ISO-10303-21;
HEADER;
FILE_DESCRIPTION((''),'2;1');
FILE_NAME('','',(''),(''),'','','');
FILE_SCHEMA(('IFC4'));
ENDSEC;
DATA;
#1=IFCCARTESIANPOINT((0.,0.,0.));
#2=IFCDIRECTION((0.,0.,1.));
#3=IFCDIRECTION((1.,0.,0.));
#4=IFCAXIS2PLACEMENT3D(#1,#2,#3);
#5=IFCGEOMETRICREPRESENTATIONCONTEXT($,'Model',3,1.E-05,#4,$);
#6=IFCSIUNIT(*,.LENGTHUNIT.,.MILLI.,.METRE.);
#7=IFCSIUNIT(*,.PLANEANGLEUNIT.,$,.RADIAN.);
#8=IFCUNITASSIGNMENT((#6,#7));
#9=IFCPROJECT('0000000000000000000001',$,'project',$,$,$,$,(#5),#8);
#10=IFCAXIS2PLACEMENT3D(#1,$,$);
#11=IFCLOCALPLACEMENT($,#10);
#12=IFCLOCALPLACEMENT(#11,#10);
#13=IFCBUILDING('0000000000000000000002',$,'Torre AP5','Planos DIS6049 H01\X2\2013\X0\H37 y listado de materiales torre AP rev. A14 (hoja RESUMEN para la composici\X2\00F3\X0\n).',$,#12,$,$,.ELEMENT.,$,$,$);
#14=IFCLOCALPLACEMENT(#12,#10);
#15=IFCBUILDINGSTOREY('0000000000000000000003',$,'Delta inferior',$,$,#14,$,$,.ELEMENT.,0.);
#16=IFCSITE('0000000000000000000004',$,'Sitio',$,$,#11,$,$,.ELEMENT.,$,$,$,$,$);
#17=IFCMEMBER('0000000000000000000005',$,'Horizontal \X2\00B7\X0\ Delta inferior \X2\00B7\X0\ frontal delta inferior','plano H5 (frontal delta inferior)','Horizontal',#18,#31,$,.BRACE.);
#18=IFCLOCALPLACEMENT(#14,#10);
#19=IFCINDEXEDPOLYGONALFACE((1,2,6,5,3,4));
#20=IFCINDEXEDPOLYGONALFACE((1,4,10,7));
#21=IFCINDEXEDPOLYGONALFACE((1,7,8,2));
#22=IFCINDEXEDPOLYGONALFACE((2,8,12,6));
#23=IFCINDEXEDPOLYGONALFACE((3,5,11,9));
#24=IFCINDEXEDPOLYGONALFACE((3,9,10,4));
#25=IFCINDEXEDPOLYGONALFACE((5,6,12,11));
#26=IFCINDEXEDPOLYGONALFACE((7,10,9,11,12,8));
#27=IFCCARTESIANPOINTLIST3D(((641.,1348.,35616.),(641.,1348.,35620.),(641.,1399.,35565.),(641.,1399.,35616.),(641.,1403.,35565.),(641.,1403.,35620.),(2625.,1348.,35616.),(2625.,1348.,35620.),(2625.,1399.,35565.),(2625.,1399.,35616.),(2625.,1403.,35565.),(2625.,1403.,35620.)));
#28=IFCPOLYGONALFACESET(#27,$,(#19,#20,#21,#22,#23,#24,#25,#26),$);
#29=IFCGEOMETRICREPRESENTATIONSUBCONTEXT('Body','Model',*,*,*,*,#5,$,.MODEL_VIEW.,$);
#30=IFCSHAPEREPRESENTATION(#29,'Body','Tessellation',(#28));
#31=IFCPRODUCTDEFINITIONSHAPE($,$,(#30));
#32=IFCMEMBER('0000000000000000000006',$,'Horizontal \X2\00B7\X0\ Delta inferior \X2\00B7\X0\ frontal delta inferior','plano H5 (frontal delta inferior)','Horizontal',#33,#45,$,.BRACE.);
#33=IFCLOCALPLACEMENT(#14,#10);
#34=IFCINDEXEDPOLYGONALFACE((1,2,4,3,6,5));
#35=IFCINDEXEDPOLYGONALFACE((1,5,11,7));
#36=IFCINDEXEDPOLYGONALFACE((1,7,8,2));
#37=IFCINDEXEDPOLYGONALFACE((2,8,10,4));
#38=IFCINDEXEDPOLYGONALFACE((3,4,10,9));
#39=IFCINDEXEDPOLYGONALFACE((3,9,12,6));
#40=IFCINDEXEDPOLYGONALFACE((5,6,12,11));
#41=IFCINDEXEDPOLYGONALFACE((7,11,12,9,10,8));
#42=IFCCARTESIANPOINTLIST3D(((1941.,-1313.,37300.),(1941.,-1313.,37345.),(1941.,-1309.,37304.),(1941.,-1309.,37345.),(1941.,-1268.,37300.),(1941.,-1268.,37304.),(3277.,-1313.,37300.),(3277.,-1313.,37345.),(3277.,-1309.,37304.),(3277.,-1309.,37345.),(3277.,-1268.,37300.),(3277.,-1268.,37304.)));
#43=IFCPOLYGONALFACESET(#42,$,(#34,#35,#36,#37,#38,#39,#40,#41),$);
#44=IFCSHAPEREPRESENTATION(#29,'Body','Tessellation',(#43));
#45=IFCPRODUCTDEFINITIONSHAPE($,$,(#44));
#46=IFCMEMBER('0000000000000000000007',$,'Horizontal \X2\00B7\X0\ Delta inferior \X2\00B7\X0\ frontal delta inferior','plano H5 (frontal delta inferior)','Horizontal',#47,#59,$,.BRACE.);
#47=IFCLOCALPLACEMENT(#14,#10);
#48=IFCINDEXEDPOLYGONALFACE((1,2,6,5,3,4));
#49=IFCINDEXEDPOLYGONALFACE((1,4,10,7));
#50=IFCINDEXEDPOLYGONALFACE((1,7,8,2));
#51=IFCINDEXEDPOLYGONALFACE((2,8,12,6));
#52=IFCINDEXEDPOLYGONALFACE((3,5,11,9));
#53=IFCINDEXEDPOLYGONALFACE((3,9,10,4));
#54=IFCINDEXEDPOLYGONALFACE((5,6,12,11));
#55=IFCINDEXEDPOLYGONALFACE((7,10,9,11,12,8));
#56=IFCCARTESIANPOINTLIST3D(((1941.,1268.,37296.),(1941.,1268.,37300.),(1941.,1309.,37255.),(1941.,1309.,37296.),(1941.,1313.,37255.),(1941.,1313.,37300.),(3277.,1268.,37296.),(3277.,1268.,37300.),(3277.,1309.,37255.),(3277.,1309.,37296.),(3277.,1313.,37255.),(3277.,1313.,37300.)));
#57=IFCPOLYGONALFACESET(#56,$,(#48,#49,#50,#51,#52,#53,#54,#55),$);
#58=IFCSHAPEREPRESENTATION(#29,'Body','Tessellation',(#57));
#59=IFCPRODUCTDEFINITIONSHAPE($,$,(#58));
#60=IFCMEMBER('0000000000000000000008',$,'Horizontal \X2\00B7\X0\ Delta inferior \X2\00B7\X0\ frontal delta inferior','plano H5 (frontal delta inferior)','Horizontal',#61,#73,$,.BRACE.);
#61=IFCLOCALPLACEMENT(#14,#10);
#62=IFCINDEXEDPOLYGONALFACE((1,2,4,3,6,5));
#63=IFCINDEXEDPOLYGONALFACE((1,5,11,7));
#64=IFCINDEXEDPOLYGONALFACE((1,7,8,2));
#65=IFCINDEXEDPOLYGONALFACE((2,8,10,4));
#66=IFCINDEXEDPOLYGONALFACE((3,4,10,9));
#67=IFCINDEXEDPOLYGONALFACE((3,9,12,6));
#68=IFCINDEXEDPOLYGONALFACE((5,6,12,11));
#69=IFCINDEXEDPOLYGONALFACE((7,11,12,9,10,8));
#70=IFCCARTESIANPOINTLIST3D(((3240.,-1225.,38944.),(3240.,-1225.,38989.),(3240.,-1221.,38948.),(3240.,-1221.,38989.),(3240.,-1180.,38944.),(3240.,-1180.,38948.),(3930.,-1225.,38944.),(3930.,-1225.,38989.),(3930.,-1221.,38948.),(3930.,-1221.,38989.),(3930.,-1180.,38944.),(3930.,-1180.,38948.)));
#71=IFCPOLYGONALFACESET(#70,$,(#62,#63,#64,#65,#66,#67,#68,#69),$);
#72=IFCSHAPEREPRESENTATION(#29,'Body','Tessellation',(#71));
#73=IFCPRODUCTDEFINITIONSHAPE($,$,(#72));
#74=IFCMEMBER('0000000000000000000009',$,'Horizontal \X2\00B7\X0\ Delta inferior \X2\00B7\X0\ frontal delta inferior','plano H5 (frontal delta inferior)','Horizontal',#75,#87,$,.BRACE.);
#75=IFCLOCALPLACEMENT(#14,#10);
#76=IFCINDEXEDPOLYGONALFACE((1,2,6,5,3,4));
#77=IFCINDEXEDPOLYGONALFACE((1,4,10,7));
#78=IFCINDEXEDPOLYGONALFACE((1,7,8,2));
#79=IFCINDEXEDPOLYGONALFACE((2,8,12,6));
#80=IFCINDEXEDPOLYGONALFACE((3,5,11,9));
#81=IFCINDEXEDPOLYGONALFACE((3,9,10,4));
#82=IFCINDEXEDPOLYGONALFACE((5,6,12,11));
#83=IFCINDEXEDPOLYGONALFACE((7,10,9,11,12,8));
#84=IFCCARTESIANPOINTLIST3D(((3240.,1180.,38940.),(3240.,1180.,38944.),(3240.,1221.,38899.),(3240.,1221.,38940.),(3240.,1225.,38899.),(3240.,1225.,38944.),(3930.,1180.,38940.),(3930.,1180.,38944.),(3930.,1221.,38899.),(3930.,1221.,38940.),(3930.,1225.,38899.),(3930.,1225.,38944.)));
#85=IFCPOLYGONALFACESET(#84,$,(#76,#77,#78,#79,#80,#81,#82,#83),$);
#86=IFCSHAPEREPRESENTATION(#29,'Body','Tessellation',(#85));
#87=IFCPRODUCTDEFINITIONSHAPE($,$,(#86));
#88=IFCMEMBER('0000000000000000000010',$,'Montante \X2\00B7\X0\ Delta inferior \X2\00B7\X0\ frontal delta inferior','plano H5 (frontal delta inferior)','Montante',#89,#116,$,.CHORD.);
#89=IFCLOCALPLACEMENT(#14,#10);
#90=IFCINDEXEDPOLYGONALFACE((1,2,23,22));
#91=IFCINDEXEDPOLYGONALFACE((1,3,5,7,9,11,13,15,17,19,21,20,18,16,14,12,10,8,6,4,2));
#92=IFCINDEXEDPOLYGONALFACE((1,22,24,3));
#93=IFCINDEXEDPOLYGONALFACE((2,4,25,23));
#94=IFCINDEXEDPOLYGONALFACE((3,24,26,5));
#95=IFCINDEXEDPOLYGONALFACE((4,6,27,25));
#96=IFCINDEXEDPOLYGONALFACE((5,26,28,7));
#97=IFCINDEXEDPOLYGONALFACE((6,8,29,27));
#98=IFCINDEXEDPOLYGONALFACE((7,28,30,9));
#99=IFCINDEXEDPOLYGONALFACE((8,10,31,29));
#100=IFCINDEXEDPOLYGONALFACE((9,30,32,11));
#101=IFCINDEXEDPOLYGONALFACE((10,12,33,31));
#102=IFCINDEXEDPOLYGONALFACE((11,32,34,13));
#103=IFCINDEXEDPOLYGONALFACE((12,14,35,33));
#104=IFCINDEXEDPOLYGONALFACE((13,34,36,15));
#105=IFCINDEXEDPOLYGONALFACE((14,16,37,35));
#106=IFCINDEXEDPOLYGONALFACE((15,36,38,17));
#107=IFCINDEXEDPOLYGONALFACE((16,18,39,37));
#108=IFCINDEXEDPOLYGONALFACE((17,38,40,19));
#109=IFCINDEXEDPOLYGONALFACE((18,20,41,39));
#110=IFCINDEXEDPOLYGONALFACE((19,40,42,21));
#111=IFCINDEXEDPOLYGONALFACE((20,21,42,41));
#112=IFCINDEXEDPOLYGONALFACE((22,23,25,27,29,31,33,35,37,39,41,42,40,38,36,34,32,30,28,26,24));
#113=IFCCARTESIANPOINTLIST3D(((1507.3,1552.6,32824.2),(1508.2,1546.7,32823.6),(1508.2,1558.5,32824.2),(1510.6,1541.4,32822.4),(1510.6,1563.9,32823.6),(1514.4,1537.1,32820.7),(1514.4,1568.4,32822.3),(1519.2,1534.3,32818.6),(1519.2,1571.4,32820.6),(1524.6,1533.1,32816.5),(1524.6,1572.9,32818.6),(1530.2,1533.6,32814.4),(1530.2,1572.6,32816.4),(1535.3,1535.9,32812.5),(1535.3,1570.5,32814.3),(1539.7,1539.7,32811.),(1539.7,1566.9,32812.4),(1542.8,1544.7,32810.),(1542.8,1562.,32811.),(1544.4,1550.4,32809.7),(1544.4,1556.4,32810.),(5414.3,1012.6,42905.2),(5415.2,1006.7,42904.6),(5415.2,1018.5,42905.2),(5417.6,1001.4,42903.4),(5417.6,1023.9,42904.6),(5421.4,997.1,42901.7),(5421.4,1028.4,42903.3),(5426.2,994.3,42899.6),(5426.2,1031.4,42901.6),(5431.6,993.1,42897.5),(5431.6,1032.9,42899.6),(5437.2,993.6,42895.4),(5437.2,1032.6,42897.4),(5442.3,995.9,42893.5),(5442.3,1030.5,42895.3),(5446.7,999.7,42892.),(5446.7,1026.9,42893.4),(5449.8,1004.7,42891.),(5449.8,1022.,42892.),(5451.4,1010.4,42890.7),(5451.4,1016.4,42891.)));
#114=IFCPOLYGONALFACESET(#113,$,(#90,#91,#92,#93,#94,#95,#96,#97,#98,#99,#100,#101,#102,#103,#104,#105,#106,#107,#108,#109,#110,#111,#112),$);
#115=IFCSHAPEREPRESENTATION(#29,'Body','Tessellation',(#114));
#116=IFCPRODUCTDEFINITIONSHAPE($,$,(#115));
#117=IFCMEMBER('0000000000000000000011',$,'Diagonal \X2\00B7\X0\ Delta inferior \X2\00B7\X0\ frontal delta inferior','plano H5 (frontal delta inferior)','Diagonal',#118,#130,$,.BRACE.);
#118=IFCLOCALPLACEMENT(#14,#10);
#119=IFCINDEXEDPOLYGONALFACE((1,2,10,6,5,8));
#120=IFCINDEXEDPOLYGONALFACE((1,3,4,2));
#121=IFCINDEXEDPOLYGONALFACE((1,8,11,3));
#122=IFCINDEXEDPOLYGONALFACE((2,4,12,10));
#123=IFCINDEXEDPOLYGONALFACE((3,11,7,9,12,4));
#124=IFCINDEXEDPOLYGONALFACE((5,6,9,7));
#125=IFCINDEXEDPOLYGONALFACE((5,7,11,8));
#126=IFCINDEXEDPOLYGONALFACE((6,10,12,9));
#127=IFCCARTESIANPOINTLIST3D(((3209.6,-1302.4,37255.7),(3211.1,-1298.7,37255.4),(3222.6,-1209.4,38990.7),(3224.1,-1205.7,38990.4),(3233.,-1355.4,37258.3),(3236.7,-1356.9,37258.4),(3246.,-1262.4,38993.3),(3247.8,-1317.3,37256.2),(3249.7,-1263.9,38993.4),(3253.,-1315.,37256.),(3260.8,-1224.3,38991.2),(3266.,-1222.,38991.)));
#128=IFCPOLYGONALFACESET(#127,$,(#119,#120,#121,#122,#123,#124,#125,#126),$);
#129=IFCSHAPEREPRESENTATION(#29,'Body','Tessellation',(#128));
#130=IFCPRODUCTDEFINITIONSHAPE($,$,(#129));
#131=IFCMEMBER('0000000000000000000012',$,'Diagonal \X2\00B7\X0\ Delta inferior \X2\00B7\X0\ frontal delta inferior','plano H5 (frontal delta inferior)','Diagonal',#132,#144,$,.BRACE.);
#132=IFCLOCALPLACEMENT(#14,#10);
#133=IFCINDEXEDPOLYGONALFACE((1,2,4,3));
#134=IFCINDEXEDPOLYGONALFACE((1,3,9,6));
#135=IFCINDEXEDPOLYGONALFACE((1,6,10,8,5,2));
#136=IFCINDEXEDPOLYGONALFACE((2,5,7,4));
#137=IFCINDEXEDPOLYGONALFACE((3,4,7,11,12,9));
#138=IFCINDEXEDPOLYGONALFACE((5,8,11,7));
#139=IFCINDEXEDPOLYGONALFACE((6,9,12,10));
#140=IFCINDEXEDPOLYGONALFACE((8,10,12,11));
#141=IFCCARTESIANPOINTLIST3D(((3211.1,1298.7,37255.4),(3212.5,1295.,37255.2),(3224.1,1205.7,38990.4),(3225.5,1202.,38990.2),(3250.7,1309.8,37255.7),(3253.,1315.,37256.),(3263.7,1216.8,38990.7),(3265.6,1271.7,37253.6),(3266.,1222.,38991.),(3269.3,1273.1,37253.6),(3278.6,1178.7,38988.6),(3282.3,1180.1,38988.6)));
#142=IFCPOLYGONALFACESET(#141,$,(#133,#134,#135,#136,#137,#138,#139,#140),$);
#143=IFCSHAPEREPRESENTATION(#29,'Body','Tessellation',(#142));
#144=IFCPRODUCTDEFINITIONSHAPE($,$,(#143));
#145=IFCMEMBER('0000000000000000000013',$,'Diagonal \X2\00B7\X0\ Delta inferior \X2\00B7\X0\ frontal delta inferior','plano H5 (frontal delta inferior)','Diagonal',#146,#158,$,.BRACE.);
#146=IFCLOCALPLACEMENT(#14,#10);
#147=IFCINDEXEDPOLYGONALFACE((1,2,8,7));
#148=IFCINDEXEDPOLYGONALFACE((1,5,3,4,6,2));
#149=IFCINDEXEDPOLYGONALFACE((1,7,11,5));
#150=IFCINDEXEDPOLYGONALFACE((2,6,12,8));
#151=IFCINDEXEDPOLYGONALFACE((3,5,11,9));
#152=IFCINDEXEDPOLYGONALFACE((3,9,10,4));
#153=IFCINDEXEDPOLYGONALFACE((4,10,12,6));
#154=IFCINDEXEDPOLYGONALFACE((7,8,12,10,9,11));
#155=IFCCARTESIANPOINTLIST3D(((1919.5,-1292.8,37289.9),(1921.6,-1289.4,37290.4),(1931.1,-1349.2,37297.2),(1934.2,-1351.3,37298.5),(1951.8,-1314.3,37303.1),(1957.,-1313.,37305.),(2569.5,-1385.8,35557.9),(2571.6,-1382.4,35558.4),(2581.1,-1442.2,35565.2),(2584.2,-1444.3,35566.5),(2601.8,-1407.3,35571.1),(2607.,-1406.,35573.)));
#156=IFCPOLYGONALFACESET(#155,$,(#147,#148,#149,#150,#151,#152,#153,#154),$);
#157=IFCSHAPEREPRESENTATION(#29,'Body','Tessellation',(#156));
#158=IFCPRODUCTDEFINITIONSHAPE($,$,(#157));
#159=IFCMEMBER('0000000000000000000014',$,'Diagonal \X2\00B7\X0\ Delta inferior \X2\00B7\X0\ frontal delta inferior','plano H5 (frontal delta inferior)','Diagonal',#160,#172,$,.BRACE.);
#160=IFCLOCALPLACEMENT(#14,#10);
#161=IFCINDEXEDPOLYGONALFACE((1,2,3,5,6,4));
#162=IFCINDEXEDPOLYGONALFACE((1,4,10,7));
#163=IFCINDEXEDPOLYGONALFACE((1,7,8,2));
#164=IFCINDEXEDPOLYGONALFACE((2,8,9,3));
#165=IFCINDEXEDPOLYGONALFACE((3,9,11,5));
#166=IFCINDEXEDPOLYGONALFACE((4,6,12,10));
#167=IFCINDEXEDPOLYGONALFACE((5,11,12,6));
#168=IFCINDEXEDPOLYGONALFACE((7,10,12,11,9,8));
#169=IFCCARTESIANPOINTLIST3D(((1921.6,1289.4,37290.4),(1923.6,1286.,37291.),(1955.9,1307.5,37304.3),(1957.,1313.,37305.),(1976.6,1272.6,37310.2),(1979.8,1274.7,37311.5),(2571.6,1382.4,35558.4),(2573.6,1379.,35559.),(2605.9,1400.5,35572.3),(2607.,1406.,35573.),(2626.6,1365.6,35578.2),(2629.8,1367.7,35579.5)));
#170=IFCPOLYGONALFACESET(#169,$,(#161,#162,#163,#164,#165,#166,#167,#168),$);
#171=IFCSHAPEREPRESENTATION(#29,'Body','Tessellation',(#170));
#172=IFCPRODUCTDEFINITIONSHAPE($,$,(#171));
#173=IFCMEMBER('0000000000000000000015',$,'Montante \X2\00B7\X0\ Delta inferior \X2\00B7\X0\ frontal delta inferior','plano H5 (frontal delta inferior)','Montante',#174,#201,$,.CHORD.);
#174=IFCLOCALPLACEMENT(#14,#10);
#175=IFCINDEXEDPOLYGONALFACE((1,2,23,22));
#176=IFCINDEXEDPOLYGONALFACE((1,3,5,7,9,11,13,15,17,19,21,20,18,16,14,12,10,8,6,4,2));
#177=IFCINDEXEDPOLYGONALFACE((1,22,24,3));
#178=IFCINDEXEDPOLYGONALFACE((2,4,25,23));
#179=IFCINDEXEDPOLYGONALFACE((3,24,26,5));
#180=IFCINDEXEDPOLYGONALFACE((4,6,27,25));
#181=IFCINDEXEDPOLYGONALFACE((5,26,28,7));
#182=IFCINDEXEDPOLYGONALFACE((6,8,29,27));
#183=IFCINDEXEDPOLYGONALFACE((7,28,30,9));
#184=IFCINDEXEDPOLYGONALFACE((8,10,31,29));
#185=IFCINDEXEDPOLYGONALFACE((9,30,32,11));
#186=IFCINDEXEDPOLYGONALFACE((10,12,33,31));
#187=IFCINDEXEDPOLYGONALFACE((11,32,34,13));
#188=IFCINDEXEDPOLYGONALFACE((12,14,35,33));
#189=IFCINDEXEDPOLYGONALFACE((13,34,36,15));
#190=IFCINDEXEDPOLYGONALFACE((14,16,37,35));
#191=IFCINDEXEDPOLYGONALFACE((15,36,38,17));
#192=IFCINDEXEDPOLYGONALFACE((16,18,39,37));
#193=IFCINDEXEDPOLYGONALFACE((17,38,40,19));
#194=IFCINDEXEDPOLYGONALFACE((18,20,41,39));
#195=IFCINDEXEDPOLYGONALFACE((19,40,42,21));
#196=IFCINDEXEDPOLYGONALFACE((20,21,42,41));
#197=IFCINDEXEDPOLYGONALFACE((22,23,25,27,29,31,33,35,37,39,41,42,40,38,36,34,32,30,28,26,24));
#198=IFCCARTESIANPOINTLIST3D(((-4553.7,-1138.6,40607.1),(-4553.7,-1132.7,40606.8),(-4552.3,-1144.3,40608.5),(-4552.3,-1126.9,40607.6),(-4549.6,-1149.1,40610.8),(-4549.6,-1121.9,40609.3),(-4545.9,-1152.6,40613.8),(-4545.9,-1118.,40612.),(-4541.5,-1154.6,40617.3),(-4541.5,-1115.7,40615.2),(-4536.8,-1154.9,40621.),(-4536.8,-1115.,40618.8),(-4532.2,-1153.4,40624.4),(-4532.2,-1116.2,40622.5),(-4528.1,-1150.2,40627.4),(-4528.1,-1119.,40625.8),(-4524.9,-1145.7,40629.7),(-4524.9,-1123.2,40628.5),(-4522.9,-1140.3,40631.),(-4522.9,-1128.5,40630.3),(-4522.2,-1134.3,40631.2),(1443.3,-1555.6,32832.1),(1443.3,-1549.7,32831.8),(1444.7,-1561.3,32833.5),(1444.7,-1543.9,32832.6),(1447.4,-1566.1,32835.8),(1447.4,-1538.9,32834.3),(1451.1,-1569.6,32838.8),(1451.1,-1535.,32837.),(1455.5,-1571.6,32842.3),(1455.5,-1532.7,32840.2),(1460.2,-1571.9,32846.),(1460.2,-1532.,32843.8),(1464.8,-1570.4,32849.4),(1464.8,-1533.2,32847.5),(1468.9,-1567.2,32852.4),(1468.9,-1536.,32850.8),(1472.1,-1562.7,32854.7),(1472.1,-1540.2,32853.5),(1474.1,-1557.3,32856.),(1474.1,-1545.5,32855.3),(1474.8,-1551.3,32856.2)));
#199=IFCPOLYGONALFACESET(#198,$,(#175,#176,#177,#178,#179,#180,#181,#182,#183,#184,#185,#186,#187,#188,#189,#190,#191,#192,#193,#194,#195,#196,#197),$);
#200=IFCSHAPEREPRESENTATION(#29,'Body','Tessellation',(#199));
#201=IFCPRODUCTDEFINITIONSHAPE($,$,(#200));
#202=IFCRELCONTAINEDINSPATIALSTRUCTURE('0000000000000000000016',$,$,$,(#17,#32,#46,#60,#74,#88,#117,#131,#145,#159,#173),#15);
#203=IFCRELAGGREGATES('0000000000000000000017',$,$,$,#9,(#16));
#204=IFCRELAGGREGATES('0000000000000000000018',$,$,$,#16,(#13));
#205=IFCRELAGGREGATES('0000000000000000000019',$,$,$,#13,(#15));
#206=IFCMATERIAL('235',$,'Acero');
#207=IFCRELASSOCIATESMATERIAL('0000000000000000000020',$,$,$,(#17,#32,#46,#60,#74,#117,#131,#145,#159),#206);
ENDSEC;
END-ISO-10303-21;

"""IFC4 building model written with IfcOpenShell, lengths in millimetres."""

from ifc_helpers import new_model, si_unit, frame, frame_2d, origin, origin_with_axes, place, context, subcontext, project, spatial, circle, l_section, extrude, material, element, save


model = new_model("IFC4")

# Units and contexts
model_context = context("Model", 3, precision=1e-05, world=origin_with_axes())
body_context = subcontext(model_context, "Body", "Model", "MODEL_VIEW")
ifc_project = project(units=[si_unit("LENGTHUNIT", "METRE", prefix="MILLI"), si_unit("PLANEANGLEUNIT", "RADIAN")], contexts=[model_context])

# Site, building, storey
site_placement = place(None, origin())
site = spatial("IfcSite", under=ifc_project, at=site_placement, Name="Sitio", CompositionType="ELEMENT")
building_placement = place(site_placement, origin())
building = spatial("IfcBuilding", under=site, at=building_placement, Name="Torre AP5", Description="Planos DIS6049 H01–H37 y listado de materiales torre AP rev. A14 (hoja RESUMEN para la composición).", CompositionType="ELEMENT")
storey_placement = place(building_placement, origin())
storey = spatial("IfcBuildingStorey", under=building, at=storey_placement, Name="Delta inferior", CompositionType="ELEMENT", Elevation=0.0)

# Members
ifc_material_1 = material(Name="235", Category="Acero")
member_1_placement = place(storey_placement, frame((641.0, 1403.0, 35620.0), z_axis=(1.0, 0.0, 0.0), x_axis=(0.0, -1.0, 0.0)))
element("IfcMember", 1, at=member_1_placement, inside=storey, material=ifc_material_1, Name="Horizontal · Delta inferior · frontal delta inferior", Description="plano H5 (frontal delta inferior)", ObjectType="Horizontal", PredefinedType="BRACE", context=body_context, shape_type="SweptSolid", body=[
    extrude(l_section(Depth=55.0, Width=55.0, Thickness=4.0, at=frame_2d((27.5, 27.5))), None, (0.0, 0.0, 1.0), 1984.0),
])
for number, where, z_axis, x_axis, name in (
    (2, (1941.0, -1313.0, 37300.0), (1.0, 0.0, 0.0), (0.0, 1.0, 0.0), "Horizontal · Delta inferior · frontal delta inferior"),
    (3, (1941.0, 1313.0, 37300.0), (1.0, 0.0, 0.0), (0.0, -1.0, 0.0), "Horizontal · Delta inferior · frontal delta inferior"),
):
    element("IfcMember", number, at=place(storey_placement, frame(where, z_axis=z_axis, x_axis=x_axis)), inside=storey, material=ifc_material_1, Name=name, Description="plano H5 (frontal delta inferior)", ObjectType="Horizontal", PredefinedType="BRACE", context=body_context, shape_type="SweptSolid", body=[
        extrude(l_section(Depth=45.0, Width=45.0, Thickness=4.0, at=frame_2d((22.5, 22.5))), None, (0.0, 0.0, 1.0), 1336.0),
    ])
for number, where, z_axis, x_axis, name in (
    (4, (3240.0, -1225.0, 38944.0), (1.0, 0.0, 0.0), (0.0, 1.0, 0.0), "Horizontal · Delta inferior · frontal delta inferior"),
    (5, (3240.0, 1225.0, 38944.0), (1.0, 0.0, 0.0), (0.0, -1.0, 0.0), "Horizontal · Delta inferior · frontal delta inferior"),
):
    element("IfcMember", number, at=place(storey_placement, frame(where, z_axis=z_axis, x_axis=x_axis)), inside=storey, material=ifc_material_1, Name=name, Description="plano H5 (frontal delta inferior)", ObjectType="Horizontal", PredefinedType="BRACE", context=body_context, shape_type="SweptSolid", body=[
        extrude(l_section(Depth=45.0, Width=45.0, Thickness=4.0, at=frame_2d((22.5, 22.5))), None, (0.0, 0.0, 1.0), 690.0),
    ])
for number, where, z_axis, x_axis, name in (
    (6, (1526.0, 1553.0, 32817.0), (0.36092, -0.049884, 0.931262), (-0.932597, -0.019305, 0.360404), "Montante · Delta inferior · frontal delta inferior"),
):
    element("IfcMember", number, at=place(storey_placement, frame(where, z_axis=z_axis, x_axis=x_axis)), inside=storey, Name=name, Description="plano H5 (frontal delta inferior)", ObjectType="Montante", PredefinedType="CHORD", context=body_context, shape_type="SweptSolid", body=[
        extrude(circle(Radius=20.0), None, (0.0, 0.0, 1.0), 10825.1),
    ])
for number, where, z_axis, x_axis, name in (
    (7, (3253.0, -1315.0, 37256.0), (0.007482, 0.053524, 0.998539), (-0.932081, 0.362036, -0.012422), "Diagonal · Delta inferior · frontal delta inferior"),
    (8, (3253.0, 1315.0, 37256.0), (0.007482, -0.053524, 0.998539), (-0.932081, -0.362036, -0.012422), "Diagonal · Delta inferior · frontal delta inferior"),
):
    element("IfcMember", number, at=place(storey_placement, frame(where, z_axis=z_axis, x_axis=x_axis)), inside=storey, material=ifc_material_1, Name=name, Description="plano H5 (frontal delta inferior)", ObjectType="Diagonal", PredefinedType="BRACE", context=body_context, shape_type="SweptSolid", body=[
        extrude(l_section(Depth=45.0, Width=45.0, Thickness=4.0, at=frame_2d((22.5, 22.5))), None, (0.0, 0.0, 1.0), 1737.5),
    ])
for number, where, z_axis, x_axis, name in (
    (9, (2607.0, -1406.0, 35573.0), (-0.350917, 0.050208, 0.935059), (-0.787637, 0.524232, -0.32374), "Diagonal · Delta inferior · frontal delta inferior"),
    (10, (2607.0, 1406.0, 35573.0), (-0.350917, -0.050208, 0.935059), (-0.787637, -0.524232, -0.32374), "Diagonal · Delta inferior · frontal delta inferior"),
):
    element("IfcMember", number, at=place(storey_placement, frame(where, z_axis=z_axis, x_axis=x_axis)), inside=storey, material=ifc_material_1, Name=name, Description="plano H5 (frontal delta inferior)", ObjectType="Diagonal", PredefinedType="BRACE", context=body_context, shape_type="SweptSolid", body=[
        extrude(l_section(Depth=45.0, Width=45.0, Thickness=4.0, at=frame_2d((22.5, 22.5))), None, (0.0, 0.0, 1.0), 1852.3),
    ])
for number, where, z_axis, x_axis, name in (
    (11, (1459.0, -1552.0, 32844.0), (-0.610199, 0.04243, 0.791111), (0.792248, 0.03268, 0.609323), "Montante · Delta inferior · frontal delta inferior"),
):
    element("IfcMember", number, at=place(storey_placement, frame(where, z_axis=z_axis, x_axis=x_axis)), inside=storey, Name=name, Description="plano H5 (frontal delta inferior)", ObjectType="Montante", PredefinedType="CHORD", context=body_context, shape_type="SweptSolid", body=[
        extrude(circle(Radius=20.0), None, (0.0, 0.0, 1.0), 9827.9),
    ])

save(model, "model.ifc")
